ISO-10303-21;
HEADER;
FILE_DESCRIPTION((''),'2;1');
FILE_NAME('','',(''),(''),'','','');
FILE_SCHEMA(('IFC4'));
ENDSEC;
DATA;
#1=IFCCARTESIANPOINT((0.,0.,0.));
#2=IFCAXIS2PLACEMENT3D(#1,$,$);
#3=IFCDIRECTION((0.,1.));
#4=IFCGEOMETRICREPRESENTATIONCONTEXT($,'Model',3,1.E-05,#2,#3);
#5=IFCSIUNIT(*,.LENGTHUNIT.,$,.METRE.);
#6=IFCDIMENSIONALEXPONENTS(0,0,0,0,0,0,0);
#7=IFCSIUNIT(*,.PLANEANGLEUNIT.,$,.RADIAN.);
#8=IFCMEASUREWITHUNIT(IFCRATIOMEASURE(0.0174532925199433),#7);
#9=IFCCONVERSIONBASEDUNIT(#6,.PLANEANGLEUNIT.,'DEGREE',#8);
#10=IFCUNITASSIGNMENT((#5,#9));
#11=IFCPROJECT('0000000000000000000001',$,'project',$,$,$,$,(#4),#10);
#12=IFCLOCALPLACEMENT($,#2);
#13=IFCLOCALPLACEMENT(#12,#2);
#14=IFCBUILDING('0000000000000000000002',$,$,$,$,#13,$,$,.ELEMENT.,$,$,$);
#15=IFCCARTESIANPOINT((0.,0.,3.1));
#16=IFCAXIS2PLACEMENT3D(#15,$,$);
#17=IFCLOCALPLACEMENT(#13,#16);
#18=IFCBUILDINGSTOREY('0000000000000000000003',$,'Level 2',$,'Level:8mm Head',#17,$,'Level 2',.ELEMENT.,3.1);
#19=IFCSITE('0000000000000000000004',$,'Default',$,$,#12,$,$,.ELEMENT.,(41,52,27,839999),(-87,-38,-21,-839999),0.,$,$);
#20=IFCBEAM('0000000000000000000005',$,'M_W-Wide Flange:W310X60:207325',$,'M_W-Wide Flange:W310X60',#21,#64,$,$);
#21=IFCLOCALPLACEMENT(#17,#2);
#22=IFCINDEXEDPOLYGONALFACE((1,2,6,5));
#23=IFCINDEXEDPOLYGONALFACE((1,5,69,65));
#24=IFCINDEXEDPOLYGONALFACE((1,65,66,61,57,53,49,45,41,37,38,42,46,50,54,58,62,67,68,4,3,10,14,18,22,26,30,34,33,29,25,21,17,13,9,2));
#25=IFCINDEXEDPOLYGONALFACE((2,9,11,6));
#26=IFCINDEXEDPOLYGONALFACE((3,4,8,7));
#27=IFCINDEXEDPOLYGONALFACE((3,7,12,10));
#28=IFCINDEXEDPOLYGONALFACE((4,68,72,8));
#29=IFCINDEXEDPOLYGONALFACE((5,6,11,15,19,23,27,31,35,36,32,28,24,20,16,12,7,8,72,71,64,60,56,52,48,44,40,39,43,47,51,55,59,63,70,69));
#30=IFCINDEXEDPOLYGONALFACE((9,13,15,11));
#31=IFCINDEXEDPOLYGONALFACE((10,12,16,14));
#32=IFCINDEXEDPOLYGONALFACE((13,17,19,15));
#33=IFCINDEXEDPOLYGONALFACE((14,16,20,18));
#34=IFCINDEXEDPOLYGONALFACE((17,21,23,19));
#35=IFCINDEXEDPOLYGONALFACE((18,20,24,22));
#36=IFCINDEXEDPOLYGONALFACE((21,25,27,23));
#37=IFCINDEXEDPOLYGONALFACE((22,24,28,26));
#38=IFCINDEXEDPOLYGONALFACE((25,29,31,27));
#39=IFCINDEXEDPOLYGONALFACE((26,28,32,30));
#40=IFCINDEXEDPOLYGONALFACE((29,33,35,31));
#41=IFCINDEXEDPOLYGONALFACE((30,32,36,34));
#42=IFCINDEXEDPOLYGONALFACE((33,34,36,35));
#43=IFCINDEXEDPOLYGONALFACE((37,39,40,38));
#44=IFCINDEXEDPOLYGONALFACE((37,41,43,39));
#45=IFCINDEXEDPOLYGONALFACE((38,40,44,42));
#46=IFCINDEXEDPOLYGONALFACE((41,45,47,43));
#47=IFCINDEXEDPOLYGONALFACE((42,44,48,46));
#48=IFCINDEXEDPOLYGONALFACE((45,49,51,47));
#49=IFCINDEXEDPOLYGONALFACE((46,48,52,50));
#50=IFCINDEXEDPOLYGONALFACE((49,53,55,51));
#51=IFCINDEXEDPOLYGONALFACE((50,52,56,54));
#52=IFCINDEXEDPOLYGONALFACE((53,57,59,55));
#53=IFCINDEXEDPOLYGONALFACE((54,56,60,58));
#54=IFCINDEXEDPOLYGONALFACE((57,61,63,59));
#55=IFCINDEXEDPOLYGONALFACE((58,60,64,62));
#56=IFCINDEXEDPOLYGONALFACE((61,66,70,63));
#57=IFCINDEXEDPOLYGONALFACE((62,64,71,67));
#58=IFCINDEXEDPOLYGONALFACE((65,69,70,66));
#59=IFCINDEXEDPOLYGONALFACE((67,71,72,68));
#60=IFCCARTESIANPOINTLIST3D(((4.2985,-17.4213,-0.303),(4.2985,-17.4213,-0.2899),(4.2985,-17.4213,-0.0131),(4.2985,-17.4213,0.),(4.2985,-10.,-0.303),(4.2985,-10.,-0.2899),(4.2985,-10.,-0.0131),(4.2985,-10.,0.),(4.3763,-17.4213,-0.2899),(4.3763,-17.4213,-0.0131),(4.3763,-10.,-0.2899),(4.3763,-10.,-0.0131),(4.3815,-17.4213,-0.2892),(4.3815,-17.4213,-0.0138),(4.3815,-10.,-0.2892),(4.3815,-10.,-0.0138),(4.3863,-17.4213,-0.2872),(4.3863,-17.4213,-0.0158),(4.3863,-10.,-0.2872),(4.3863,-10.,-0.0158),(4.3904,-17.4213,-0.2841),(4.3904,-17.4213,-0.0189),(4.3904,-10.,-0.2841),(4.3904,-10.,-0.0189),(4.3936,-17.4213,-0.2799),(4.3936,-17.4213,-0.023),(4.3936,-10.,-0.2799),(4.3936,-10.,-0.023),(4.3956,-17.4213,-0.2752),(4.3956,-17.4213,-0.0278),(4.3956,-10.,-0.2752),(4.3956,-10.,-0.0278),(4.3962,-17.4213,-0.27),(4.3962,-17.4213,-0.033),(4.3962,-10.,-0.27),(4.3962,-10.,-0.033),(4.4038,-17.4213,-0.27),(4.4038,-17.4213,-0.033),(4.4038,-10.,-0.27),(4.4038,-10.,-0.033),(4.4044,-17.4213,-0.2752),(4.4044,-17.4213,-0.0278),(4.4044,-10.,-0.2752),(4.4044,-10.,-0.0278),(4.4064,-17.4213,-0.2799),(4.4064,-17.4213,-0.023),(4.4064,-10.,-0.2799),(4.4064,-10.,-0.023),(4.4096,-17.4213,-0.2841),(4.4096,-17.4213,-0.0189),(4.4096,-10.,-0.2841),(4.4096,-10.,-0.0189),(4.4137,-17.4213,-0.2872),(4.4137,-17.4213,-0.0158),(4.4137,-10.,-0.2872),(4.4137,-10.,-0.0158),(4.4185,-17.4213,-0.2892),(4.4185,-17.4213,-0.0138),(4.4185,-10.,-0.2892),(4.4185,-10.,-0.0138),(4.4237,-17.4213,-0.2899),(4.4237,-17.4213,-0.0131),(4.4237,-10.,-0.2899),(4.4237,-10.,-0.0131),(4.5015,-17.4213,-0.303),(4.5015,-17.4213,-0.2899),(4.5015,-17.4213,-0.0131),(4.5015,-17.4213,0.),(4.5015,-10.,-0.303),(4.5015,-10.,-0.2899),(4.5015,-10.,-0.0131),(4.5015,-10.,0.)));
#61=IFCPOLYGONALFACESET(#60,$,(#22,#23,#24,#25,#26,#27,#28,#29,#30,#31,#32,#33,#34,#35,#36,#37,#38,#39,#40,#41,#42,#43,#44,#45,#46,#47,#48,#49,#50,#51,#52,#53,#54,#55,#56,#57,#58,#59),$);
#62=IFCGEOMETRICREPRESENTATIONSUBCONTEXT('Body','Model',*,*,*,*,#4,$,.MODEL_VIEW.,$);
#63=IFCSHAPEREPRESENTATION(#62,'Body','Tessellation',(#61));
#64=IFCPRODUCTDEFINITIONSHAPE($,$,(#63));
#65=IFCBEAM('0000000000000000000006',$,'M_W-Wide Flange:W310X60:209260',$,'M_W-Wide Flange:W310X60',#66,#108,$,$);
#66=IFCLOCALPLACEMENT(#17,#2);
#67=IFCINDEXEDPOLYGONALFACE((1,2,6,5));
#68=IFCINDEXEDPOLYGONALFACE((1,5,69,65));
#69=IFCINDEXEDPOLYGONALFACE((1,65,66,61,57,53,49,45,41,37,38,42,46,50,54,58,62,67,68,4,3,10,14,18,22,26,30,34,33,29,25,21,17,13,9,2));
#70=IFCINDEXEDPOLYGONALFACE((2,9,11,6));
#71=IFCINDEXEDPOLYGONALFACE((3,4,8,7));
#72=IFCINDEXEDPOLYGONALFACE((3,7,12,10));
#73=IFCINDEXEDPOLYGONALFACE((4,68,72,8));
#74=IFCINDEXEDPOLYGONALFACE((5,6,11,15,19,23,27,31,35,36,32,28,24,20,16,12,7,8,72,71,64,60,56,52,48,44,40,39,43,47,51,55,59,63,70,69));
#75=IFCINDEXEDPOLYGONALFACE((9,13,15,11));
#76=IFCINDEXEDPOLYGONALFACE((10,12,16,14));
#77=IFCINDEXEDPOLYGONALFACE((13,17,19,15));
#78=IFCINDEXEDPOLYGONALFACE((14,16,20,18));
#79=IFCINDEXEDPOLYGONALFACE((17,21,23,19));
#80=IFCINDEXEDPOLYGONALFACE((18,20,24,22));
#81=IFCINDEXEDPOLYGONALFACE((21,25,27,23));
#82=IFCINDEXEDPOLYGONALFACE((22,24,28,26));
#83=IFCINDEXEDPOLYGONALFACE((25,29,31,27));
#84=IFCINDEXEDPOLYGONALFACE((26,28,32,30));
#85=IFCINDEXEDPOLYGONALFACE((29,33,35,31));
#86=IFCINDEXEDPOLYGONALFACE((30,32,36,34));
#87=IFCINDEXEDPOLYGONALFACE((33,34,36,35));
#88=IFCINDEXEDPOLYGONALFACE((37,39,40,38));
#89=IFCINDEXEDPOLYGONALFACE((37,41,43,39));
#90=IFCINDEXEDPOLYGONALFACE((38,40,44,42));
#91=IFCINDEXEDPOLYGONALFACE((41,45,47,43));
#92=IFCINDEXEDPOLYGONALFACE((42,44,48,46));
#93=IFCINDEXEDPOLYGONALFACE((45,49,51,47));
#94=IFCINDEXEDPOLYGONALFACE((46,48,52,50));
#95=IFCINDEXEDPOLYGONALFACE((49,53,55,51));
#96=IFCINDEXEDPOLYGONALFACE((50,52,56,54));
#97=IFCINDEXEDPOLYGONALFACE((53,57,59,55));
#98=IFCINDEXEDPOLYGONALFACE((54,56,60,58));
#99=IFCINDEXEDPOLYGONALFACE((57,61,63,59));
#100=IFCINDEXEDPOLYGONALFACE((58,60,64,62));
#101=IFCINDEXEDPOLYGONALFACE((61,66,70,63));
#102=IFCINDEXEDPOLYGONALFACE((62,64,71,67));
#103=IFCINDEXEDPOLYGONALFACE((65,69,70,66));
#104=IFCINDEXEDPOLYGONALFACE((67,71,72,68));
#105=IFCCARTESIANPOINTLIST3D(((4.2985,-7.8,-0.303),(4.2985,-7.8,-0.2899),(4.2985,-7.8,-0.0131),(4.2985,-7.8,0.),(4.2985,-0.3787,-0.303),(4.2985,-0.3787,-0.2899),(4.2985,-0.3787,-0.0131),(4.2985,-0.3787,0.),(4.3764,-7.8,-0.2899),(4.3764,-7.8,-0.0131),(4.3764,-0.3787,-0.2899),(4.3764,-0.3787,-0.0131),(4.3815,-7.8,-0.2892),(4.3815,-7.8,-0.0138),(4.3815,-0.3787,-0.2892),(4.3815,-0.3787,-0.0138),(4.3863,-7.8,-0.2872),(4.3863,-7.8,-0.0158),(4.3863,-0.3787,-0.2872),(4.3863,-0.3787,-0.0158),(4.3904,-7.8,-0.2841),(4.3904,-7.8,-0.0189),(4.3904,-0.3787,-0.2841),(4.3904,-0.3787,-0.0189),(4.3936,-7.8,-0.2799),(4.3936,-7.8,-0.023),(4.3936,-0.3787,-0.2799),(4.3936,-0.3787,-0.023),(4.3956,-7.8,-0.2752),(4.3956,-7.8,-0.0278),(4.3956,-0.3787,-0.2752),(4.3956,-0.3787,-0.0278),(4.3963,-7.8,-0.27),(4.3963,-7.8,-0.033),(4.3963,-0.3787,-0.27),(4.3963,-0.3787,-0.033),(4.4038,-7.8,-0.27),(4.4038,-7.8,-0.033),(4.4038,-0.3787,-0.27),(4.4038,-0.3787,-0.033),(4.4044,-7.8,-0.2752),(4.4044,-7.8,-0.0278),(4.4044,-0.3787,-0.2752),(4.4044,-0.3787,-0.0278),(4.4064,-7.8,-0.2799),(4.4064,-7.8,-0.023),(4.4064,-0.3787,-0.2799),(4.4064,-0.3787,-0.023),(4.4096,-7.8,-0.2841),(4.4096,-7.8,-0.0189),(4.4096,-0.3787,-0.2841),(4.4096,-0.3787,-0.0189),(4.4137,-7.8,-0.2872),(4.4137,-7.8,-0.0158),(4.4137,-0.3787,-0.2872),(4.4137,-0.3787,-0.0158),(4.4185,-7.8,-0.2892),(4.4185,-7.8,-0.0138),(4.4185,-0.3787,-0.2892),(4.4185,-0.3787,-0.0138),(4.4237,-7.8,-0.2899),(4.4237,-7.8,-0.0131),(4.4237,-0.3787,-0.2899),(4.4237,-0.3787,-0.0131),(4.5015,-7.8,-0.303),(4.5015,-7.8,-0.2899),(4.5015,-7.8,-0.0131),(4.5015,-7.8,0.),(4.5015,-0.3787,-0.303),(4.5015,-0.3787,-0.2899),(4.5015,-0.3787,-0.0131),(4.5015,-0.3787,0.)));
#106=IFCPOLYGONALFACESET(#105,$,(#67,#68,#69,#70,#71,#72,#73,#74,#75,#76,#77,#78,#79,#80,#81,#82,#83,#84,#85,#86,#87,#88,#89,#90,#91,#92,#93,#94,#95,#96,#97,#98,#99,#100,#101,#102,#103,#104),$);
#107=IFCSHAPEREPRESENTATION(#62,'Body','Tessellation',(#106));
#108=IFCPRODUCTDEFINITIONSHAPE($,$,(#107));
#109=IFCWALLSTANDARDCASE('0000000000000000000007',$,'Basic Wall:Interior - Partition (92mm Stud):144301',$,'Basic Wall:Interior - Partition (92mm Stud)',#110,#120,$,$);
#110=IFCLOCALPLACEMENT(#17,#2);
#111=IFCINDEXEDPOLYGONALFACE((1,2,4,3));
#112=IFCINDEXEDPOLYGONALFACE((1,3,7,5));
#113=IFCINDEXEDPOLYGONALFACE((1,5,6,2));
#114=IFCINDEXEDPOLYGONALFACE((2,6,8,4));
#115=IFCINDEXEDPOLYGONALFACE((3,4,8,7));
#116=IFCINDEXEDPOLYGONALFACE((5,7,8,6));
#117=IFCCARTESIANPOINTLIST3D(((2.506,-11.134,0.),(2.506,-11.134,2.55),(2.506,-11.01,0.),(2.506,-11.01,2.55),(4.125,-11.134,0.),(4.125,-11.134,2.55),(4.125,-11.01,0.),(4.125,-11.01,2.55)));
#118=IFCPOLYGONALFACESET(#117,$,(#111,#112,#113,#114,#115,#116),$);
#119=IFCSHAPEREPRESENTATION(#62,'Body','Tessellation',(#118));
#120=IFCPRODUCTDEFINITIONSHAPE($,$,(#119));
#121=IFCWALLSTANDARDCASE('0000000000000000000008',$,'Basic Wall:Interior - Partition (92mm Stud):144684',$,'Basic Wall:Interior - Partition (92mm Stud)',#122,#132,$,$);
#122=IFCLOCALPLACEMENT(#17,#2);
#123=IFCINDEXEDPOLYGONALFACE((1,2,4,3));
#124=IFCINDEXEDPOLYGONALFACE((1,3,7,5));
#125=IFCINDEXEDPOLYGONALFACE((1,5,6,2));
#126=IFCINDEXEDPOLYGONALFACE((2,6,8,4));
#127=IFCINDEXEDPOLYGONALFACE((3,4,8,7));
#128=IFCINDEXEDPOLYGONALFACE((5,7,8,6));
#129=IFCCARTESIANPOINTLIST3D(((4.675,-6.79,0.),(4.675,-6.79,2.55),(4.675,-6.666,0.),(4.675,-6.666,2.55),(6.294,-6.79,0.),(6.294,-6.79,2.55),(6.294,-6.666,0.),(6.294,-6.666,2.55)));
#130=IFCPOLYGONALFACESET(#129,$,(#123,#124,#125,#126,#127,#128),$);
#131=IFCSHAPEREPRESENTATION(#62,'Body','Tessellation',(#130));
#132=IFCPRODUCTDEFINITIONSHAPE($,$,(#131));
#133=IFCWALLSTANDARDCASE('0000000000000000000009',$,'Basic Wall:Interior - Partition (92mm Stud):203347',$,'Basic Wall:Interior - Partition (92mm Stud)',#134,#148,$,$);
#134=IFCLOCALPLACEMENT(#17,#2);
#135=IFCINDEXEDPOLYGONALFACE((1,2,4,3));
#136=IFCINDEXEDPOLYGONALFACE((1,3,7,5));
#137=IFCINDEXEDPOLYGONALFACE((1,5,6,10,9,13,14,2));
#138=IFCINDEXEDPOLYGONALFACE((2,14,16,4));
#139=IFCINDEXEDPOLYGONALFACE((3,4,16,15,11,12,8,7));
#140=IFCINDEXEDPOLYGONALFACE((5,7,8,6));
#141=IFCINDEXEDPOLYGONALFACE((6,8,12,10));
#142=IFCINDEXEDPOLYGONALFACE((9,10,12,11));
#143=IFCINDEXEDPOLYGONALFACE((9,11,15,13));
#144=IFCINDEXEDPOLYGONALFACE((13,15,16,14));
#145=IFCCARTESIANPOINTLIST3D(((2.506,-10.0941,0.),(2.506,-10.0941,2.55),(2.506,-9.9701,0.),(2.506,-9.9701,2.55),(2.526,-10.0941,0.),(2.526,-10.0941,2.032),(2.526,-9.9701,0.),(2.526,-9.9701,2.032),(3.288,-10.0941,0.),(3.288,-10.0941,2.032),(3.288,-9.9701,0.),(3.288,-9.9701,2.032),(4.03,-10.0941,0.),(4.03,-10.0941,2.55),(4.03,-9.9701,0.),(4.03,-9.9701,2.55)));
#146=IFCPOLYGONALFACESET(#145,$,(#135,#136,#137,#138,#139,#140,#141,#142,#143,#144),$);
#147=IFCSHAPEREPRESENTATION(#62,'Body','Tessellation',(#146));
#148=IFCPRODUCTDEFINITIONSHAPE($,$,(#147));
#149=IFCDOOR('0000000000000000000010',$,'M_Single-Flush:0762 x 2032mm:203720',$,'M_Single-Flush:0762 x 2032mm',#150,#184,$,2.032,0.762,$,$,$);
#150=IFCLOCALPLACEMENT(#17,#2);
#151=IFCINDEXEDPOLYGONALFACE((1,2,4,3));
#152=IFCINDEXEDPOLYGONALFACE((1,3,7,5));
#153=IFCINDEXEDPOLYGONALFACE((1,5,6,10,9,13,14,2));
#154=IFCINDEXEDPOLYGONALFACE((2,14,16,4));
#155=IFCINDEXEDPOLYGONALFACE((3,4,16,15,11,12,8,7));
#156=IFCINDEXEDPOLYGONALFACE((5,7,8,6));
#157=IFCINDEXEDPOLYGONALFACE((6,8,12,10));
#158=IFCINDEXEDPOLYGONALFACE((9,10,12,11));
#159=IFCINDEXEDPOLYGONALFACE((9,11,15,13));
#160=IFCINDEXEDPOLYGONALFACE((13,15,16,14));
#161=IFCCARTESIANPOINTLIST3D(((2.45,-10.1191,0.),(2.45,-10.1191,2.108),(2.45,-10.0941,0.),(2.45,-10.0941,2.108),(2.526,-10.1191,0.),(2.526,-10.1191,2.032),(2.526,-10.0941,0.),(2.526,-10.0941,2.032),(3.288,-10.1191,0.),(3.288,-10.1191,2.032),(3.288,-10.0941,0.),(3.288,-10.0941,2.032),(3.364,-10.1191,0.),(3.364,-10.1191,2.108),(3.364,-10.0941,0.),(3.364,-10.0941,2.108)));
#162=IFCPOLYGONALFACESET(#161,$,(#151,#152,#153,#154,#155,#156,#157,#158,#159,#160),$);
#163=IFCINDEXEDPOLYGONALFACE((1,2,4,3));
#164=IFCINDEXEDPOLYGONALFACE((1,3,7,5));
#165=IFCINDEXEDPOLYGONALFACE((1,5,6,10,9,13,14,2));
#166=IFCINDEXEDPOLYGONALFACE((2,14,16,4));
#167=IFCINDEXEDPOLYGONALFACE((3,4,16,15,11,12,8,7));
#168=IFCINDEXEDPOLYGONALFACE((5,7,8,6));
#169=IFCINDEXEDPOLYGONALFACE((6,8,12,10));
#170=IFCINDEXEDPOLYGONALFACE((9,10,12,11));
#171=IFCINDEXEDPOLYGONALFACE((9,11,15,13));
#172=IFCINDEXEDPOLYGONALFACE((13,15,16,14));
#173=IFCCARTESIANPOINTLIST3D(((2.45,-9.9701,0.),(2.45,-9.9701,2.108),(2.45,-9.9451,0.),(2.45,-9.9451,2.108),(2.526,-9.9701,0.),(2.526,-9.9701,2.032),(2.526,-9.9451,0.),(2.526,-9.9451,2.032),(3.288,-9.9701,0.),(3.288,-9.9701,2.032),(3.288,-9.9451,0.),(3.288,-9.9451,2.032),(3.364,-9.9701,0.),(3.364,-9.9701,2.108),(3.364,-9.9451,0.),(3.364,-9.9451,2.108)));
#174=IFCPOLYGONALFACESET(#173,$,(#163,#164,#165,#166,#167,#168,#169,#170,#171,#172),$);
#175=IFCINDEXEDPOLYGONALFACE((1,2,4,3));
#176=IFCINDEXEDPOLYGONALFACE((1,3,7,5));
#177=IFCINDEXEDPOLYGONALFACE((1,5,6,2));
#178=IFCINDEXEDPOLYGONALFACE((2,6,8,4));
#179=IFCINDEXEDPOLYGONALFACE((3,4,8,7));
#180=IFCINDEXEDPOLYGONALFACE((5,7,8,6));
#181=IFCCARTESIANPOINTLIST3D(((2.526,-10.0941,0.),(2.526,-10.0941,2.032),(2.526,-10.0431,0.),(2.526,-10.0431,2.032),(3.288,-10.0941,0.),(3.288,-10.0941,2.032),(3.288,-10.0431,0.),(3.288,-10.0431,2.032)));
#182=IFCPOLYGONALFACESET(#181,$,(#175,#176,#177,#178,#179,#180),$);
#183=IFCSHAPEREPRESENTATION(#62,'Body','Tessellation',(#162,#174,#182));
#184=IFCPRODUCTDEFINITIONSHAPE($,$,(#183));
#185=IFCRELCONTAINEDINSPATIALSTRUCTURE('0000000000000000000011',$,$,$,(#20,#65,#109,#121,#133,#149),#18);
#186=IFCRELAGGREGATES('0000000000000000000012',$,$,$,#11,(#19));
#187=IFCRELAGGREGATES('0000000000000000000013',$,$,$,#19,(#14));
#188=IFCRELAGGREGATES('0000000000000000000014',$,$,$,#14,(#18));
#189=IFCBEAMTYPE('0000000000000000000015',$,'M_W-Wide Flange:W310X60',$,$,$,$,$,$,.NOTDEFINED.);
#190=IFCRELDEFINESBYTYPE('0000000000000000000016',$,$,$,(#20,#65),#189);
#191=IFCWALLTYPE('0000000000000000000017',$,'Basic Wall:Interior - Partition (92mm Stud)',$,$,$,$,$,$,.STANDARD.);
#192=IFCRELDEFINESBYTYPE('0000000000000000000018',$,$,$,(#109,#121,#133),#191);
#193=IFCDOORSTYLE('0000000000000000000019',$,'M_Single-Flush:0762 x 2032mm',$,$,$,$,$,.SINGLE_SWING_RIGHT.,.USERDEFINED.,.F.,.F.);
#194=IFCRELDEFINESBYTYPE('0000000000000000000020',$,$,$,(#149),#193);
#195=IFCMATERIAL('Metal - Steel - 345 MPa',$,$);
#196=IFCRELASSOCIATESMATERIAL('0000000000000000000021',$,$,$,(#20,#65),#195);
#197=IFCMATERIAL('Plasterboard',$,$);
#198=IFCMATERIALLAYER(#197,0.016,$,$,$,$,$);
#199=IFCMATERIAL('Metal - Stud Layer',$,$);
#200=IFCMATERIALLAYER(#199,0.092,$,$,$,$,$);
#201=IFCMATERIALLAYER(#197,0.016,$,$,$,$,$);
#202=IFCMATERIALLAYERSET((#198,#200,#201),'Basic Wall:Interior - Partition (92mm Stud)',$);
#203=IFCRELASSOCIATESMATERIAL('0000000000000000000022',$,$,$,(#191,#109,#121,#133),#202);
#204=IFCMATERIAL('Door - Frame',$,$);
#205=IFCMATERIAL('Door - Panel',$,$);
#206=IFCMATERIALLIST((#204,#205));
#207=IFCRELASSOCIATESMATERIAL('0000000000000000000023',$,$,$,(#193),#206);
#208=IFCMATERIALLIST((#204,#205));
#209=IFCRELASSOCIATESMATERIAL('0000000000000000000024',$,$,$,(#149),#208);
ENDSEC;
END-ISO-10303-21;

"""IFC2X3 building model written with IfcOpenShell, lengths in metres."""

from ifc_helpers import new_model, entity, si_unit, converted_unit, direction, frame, frame_2d, origin, origin_2d_with_axis, place, context, subcontext, project, spatial, polyline, rectangle, i_section, outline, extrude, source, transform, mapped, material, material_list, layer, layer_set, layer_usage, type_object, type_shapes, element, fill, save


model = new_model("IFC2X3")

# Units and contexts
model_context = context("Model", 3, precision=1e-05, world=origin(), true_north=direction((0.0, 1.0)))
body_context = subcontext(model_context, "Body", "Model", "MODEL_VIEW")
ifc_project = project(units=[si_unit("LENGTHUNIT", "METRE"), converted_unit("PLANEANGLEUNIT", "DEGREE", entity("IfcRatioMeasure", 0.0174532925199433), si_unit("PLANEANGLEUNIT", "RADIAN"), dimensions=[0, 0, 0, 0, 0, 0, 0])], contexts=[model_context])

# Site, building, storey
site_placement = place(None, origin())
site = spatial("IfcSite", under=ifc_project, at=site_placement, Name="Default", CompositionType="ELEMENT", RefLatitude=(41, 52, 27, 839999), RefLongitude=(-87, -38, -21, -839999), RefElevation=0.0)
building_placement = place(site_placement, origin())
building = spatial("IfcBuilding", under=site, at=building_placement, CompositionType="ELEMENT")
storey_placement = place(building_placement, frame((0.0, 0.0, 3.1)))
storey = spatial("IfcBuildingStorey", under=building, at=storey_placement, Name="Level 2", ObjectType="Level:8mm Head", LongName="Level 2", CompositionType="ELEMENT", Elevation=3.1)

# Beams
ifc_material_1 = material(Name="Metal - Steel - 345 MPa")
beam_type = type_object("IfcBeamType", Name="M_W-Wide Flange:W310X60", PredefinedType="NOTDEFINED")
beam_1_placement = place(storey_placement, frame((4.4, -10.0, 0.0), z_axis=(0.0, 0.0, 1.0), x_axis=(0.0, -1.0, 0.0)))
element("IfcBeam", 1, at=beam_1_placement, inside=storey, type_object=beam_type, material=ifc_material_1, Name="M_W-Wide Flange:W310X60:207325", ObjectType="M_W-Wide Flange:W310X60", context=body_context, shape_type="SweptSolid", body=[
    extrude(i_section(OverallWidth=0.203, OverallDepth=0.303, WebThickness=0.0075, FlangeThickness=0.0131, FilletRadius=0.0199, at=frame_2d((0.0, 0.0), x_axis=(0.0, 1.0))), frame((0.0, 0.0, -0.1515), z_axis=(1.0, 0.0, 0.0), x_axis=(0.0, 0.0, -1.0)), (0.0, 0.0, 1.0), 7.4213),
])
beam_2_placement = place(storey_placement, frame((4.4, -7.8, 0.0), z_axis=(0.0, 0.0, 1.0), x_axis=(0.0, 1.0, 0.0)))
element("IfcBeam", 2, at=beam_2_placement, inside=storey, type_object=beam_type, material=ifc_material_1, Name="M_W-Wide Flange:W310X60:209260", ObjectType="M_W-Wide Flange:W310X60", context=body_context, shape_type="SweptSolid", body=[
    extrude(i_section(OverallWidth=0.203, OverallDepth=0.303, WebThickness=0.0075, FlangeThickness=0.0131, FilletRadius=0.0199, at=frame_2d((0.0, 0.0), x_axis=(0.0, 1.0))), frame((0.0, 0.0, -0.1515), z_axis=(1.0, 0.0, 0.0), x_axis=(0.0, 0.0, -1.0)), (0.0, 0.0, 1.0), 7.4213),
])

# Walls
ifc_material_2 = material(Name="Plasterboard")
ifc_layer_1 = layer(ifc_material_2, 0.016)
ifc_material_3 = material(Name="Metal - Stud Layer")
ifc_layer_2 = layer(ifc_material_3, 0.092)
ifc_layer_3 = layer(ifc_material_2, 0.016)
ifc_layer_set_1 = layer_set([ifc_layer_1, ifc_layer_2, ifc_layer_3], Name="Basic Wall:Interior - Partition (92mm Stud)")
ifc_layer_usage_1 = layer_usage(ifc_layer_set_1, "AXIS2", "NEGATIVE", 0.062)
wall_type_1 = type_object("IfcWallType", Name="Basic Wall:Interior - Partition (92mm Stud)", PredefinedType="STANDARD", material=ifc_layer_set_1)
wall_1_placement = place(storey_placement, frame((4.125, -11.072, 0.0), z_axis=(0.0, 0.0, 1.0), x_axis=(-1.0, 0.0, 0.0)))
element("IfcWallStandardCase", 3, at=wall_1_placement, inside=storey, type_object=wall_type_1, material=ifc_layer_usage_1, Name="Basic Wall:Interior - Partition (92mm Stud):144301", ObjectType="Basic Wall:Interior - Partition (92mm Stud)", context=body_context, shape_type="SweptSolid", body=[
    extrude(rectangle(XDim=1.619, YDim=0.124, at=frame_2d((0.8095, 0.0), x_axis=(-1.0, 0.0))), origin(), (0.0, 0.0, 1.0), 2.55),
])
ifc_layer_usage_2 = layer_usage(ifc_layer_set_1, "AXIS2", "NEGATIVE", 0.062)
wall_2_placement = place(storey_placement, frame((4.675, -6.728, 0.0)))
element("IfcWallStandardCase", 4, at=wall_2_placement, inside=storey, type_object=wall_type_1, material=ifc_layer_usage_2, Name="Basic Wall:Interior - Partition (92mm Stud):144684", ObjectType="Basic Wall:Interior - Partition (92mm Stud)", context=body_context, shape_type="SweptSolid", body=[
    extrude(rectangle(XDim=1.619, YDim=0.124, at=frame_2d((0.8095, 0.0), x_axis=(-1.0, 0.0))), origin(), (0.0, 0.0, 1.0), 2.55),
])

# Wall, opening, door
ifc_layer_usage_3 = layer_usage(ifc_layer_set_1, "AXIS2", "NEGATIVE", 0.062)
wall_3_placement = place(storey_placement, frame((4.03, -10.0321, 0.0), z_axis=(0.0, 0.0, 1.0), x_axis=(-1.0, 0.0, 0.0)))
wall_3 = element("IfcWallStandardCase", 5, at=wall_3_placement, inside=storey, type_object=wall_type_1, material=ifc_layer_usage_3, Name="Basic Wall:Interior - Partition (92mm Stud):203347", ObjectType="Basic Wall:Interior - Partition (92mm Stud)", context=body_context, shape_type="SweptSolid", body=[
    extrude(rectangle(XDim=1.524, YDim=0.124, at=frame_2d((0.762, 0.0), x_axis=(-1.0, 0.0))), origin(), (0.0, 0.0, 1.0), 2.55),
])
opening_1_placement = place(wall_3_placement, frame((0.742, -0.062, 0.0)))
opening_1 = element("IfcOpeningElement", 6, at=opening_1_placement, cuts=wall_3, ObjectType="Opening", context=body_context, shape_type="SweptSolid", body=[
    extrude(rectangle(XDim=0.762, YDim=2.032, at=frame_2d((1.016, 0.381), x_axis=(0.0, 1.0))), frame((0.0, 0.0, 0.0), z_axis=(0.0, 1.0, 0.0), x_axis=(0.0, 0.0, 1.0)), (0.0, 0.0, 1.0), 0.124),
])
ifc_material_4 = material(Name="Door - Frame")
ifc_material_5 = material(Name="Door - Panel")
ifc_material_list_1 = material_list([ifc_material_4, ifc_material_5])
ifc_material_list_2 = material_list([ifc_material_4, ifc_material_5])
door_style = type_object("IfcDoorStyle", Name="M_Single-Flush:0762 x 2032mm", ConstructionType="USERDEFINED", OperationType="SINGLE_SWING_RIGHT", ParameterTakesPrecedence=False, Sizeable=False, material=ifc_material_list_2)
shared_shape_1 = source(origin(), body_context, "Body", "SweptSolid", [
    extrude(outline(polyline([(-0.457, -1.073), (0.457, -1.073), (0.457, 1.035), (0.381, 1.035), (0.381, -0.997), (-0.381, -0.997), (-0.381, 1.035), (-0.457, 1.035), (-0.457, -1.073)])), frame((0.381, 0.124, 1.035), z_axis=(0.0, 1.0, 0.0), x_axis=(1.0, 0.0, 0.0)), (0.0, 0.0, 1.0), 0.025),
    extrude(outline(polyline([(-1.073, -0.457), (1.035, -0.457), (1.035, -0.381), (-0.997, -0.381), (-0.997, 0.381), (1.035, 0.381), (1.035, 0.457), (-1.073, 0.457), (-1.073, -0.457)])), frame((0.381, -0.025, 1.035), z_axis=(0.0, 1.0, 0.0), x_axis=(0.0, 0.0, -1.0)), (0.0, 0.0, 1.0), 0.025),
    extrude(rectangle(XDim=0.051, YDim=0.762, at=origin_2d_with_axis()), frame((0.381, 0.0985, 0.0), z_axis=(0.0, 0.0, 1.0), x_axis=(0.0, 1.0, 0.0)), (0.0, 0.0, 1.0), 2.032),
])
type_shapes(door_style, [shared_shape_1])
door_1_placement = place(opening_1_placement, origin())
door_1 = element("IfcDoor", 7, at=door_1_placement, inside=storey, type_object=door_style, material=ifc_material_list_1, Name="M_Single-Flush:0762 x 2032mm:203720", ObjectType="M_Single-Flush:0762 x 2032mm", OverallHeight=2.032, OverallWidth=0.762, context=body_context, shape_type="MappedRepresentation", body=[
    mapped(shared_shape_1, transform((0.0, 0.0, 0.0), scale=1.0)),
])
fill(opening_1, door_1)

save(model, "model.ifc")
